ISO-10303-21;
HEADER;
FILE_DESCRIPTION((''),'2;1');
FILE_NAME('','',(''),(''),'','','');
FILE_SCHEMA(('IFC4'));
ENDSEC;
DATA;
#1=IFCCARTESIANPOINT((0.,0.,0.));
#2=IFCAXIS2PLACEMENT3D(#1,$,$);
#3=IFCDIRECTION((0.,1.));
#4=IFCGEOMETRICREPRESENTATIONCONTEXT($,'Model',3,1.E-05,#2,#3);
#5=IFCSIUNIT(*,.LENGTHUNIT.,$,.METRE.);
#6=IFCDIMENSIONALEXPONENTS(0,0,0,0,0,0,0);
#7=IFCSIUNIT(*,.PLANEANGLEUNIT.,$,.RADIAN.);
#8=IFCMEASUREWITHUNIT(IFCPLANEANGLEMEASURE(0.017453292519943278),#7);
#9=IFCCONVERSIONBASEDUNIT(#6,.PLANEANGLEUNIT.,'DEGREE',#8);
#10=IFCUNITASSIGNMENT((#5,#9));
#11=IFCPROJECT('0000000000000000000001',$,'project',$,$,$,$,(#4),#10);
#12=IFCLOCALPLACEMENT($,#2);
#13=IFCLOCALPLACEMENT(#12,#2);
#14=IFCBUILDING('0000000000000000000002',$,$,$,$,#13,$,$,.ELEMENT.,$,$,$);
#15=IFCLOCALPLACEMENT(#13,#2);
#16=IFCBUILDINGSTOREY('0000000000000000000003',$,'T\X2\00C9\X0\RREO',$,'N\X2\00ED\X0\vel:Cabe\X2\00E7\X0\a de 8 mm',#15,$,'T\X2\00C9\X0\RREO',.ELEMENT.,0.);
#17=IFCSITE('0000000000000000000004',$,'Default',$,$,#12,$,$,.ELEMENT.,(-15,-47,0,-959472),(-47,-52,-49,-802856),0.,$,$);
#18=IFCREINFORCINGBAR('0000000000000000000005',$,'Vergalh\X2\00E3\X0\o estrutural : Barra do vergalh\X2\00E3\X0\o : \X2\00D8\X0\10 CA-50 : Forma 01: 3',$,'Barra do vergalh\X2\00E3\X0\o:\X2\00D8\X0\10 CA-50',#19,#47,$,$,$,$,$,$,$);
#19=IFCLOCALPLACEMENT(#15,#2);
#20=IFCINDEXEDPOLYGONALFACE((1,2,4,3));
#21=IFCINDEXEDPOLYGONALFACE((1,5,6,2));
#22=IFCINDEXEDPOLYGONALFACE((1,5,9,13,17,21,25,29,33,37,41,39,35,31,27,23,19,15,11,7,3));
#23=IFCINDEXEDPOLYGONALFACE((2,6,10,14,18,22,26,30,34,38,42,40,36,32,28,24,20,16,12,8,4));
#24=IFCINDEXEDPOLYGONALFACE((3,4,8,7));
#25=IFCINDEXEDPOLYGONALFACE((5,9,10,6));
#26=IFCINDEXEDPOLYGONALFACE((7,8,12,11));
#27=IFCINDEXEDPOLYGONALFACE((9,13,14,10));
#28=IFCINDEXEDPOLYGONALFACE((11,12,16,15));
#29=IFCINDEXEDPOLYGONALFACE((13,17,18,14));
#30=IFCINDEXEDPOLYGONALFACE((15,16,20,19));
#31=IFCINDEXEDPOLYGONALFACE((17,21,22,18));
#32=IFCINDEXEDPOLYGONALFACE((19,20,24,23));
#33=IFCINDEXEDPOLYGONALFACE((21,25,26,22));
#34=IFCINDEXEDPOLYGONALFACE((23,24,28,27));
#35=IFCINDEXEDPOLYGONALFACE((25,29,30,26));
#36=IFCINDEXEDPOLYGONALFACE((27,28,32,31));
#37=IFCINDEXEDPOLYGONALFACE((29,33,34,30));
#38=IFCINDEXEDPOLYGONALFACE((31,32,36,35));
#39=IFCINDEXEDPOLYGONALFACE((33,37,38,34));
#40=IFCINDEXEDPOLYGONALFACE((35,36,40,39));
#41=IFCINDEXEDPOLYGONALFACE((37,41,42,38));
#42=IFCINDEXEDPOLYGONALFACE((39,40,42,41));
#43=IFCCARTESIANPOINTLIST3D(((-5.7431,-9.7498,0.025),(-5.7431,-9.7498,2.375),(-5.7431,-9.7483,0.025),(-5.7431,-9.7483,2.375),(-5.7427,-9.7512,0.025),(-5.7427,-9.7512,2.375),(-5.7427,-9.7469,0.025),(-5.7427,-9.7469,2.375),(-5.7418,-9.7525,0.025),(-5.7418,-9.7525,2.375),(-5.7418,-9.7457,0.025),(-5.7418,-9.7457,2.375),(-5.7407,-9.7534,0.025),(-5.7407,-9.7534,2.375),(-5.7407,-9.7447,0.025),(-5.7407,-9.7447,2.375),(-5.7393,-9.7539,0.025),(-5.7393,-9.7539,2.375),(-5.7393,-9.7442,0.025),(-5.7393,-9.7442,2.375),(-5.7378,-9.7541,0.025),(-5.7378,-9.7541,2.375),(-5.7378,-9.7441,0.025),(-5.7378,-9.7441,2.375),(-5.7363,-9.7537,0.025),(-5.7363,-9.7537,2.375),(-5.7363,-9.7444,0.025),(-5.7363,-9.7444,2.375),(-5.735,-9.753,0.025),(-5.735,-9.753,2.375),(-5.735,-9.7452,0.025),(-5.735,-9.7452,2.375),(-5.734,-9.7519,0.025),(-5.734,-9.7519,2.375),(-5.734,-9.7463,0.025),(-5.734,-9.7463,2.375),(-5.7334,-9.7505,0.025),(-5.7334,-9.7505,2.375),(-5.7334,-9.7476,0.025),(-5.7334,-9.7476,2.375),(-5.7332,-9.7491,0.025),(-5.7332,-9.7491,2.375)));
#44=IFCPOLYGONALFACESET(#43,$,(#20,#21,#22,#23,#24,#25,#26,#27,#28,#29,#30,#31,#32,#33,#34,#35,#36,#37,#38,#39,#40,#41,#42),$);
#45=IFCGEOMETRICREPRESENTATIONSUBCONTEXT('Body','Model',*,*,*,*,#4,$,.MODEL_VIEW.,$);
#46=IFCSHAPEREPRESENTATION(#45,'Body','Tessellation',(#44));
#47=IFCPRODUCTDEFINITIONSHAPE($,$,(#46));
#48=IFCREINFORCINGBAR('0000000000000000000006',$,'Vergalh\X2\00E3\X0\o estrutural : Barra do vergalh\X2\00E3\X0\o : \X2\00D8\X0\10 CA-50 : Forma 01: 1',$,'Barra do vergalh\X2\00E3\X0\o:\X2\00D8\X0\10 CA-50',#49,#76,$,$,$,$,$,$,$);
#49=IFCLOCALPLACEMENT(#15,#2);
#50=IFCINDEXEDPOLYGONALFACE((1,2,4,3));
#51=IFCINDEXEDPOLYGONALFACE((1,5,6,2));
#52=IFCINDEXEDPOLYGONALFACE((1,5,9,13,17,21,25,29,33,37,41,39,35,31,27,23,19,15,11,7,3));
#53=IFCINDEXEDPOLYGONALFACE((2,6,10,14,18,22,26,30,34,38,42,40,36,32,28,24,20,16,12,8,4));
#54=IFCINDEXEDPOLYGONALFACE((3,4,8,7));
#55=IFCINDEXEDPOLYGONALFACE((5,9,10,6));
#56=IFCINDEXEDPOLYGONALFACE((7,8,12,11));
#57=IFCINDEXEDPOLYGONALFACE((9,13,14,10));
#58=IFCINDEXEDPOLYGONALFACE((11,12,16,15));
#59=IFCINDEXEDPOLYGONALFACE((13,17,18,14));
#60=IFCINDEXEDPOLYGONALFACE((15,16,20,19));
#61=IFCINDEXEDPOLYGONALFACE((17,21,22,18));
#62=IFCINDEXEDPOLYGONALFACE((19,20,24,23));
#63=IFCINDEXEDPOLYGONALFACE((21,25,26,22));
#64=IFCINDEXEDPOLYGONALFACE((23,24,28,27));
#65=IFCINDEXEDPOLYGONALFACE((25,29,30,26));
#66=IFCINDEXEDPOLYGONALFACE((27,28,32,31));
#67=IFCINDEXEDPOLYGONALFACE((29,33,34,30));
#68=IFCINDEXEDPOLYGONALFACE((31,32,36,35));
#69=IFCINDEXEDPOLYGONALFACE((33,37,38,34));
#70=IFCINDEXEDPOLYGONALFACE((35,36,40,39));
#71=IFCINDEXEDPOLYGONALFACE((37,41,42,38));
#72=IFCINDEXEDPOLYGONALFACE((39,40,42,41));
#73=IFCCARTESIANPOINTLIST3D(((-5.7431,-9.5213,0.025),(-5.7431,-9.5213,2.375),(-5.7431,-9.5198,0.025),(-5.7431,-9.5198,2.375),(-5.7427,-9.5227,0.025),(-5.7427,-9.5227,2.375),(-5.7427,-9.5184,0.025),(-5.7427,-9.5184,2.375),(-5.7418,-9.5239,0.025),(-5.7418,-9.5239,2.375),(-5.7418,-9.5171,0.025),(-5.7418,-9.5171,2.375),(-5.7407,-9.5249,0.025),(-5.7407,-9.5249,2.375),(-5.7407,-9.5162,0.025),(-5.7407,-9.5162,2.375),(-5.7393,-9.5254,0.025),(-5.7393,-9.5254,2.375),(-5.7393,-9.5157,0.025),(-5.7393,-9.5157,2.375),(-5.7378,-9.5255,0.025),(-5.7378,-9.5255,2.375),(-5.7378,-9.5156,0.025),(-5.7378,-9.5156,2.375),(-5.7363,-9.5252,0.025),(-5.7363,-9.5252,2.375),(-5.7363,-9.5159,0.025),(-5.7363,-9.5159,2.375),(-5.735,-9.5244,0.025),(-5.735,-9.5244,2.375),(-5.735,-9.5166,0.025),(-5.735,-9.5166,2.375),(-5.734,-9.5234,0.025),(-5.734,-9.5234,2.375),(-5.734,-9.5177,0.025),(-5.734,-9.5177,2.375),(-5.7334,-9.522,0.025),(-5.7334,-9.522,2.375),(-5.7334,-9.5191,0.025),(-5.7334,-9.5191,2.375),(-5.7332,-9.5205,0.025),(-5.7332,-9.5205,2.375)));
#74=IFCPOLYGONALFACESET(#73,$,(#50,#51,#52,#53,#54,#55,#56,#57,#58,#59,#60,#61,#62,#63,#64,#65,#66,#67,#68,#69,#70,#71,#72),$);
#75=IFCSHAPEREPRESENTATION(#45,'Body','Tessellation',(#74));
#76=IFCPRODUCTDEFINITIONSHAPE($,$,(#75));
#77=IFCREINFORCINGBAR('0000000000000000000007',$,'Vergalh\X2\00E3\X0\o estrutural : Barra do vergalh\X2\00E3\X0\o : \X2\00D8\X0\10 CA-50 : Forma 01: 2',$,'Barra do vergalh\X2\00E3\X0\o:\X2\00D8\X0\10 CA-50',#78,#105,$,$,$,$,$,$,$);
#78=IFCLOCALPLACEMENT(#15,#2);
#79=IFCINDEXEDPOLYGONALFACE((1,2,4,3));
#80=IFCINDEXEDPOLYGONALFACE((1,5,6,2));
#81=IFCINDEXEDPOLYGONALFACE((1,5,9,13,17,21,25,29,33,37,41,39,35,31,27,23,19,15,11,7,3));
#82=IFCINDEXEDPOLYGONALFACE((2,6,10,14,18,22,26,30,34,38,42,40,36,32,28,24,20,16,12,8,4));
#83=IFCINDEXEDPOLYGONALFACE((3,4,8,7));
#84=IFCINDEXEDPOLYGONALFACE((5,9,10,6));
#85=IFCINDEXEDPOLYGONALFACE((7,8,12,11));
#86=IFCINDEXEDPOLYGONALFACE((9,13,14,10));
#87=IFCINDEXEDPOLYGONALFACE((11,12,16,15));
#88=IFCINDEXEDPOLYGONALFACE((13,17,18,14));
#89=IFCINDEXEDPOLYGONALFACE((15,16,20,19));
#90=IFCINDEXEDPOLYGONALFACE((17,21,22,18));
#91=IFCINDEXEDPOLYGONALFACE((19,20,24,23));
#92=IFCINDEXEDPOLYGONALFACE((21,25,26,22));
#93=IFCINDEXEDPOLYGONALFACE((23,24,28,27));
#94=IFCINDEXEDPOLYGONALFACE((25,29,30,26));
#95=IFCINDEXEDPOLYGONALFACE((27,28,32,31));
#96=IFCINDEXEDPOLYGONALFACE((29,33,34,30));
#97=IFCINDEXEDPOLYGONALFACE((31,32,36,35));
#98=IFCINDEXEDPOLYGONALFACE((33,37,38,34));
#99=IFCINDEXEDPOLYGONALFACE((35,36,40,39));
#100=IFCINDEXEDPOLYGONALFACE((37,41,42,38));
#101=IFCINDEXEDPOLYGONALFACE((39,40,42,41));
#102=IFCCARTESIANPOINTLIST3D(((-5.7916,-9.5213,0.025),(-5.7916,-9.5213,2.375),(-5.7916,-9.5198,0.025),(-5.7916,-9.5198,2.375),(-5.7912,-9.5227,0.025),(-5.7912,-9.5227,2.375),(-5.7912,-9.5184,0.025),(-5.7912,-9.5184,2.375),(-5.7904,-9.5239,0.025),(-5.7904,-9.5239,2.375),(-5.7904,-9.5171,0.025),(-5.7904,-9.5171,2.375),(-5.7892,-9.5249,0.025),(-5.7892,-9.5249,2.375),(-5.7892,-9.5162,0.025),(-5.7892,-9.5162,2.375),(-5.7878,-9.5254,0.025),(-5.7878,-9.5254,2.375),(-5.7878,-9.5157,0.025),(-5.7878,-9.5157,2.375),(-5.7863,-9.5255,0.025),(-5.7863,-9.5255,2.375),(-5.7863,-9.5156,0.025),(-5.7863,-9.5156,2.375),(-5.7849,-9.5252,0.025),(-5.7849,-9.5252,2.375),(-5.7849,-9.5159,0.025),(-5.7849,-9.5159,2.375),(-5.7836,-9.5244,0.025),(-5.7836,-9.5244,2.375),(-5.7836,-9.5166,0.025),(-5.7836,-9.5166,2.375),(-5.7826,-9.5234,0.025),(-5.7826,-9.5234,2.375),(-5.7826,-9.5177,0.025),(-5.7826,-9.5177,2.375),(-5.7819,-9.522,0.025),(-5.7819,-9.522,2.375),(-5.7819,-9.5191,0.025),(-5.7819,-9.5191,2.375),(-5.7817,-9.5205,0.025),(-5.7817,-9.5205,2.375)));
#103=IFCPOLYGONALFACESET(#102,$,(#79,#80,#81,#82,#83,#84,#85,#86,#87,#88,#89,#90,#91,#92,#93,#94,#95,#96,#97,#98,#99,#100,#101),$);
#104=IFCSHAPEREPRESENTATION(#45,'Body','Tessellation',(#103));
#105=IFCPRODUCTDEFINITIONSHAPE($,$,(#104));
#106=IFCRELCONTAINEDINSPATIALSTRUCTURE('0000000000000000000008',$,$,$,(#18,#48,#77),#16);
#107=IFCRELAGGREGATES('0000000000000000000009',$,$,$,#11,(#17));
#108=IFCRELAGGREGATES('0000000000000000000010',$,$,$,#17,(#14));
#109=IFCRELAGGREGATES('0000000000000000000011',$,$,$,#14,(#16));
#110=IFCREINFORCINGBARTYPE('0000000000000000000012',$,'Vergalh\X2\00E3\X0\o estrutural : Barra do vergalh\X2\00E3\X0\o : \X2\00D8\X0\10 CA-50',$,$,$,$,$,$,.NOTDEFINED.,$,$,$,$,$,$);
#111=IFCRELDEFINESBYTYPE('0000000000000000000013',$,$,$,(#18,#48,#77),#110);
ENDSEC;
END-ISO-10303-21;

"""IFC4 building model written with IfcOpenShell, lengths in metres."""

from ifc_helpers import new_model, entity, si_unit, converted_unit, direction, origin, place, context, subcontext, project, spatial, type_object, element, save


model = new_model("IFC4")

# Units and contexts
model_context = context("Model", 3, precision=1e-05, world=origin(), true_north=direction((0.0, 1.0)))
body_context = subcontext(model_context, "Body", "Model", "MODEL_VIEW")
ifc_project = project(units=[si_unit("LENGTHUNIT", "METRE"), converted_unit("PLANEANGLEUNIT", "DEGREE", entity("IfcPlaneAngleMeasure", 0.017453292519943278), si_unit("PLANEANGLEUNIT", "RADIAN"), dimensions=[0, 0, 0, 0, 0, 0, 0])], contexts=[model_context])

# Site, building, storey
site_placement = place(None, origin())
site = spatial("IfcSite", under=ifc_project, at=site_placement, Name="Default", CompositionType="ELEMENT", RefLatitude=(-15, -47, 0, -959472), RefLongitude=(-47, -52, -49, -802856), RefElevation=0.0)
building_placement = place(site_placement, origin())
building = spatial("IfcBuilding", under=site, at=building_placement, CompositionType="ELEMENT")
storey_placement = place(building_placement, origin())
storey = spatial("IfcBuildingStorey", under=building, at=storey_placement, Name="TÉRREO", ObjectType="Nível:Cabeça de 8 mm", LongName="TÉRREO", CompositionType="ELEMENT", Elevation=0.0)

# Reinforcing bars
reinforcing_bar_type_1 = type_object("IfcReinforcingBarType", Name="Vergalhão estrutural : Barra do vergalhão : Ø10 CA-50", PredefinedType="NOTDEFINED")
reinforcing_bar_1_placement = place(storey_placement, origin())
element("IfcReinforcingBar", 1, at=reinforcing_bar_1_placement, inside=storey, type_object=reinforcing_bar_type_1, Name="Vergalhão estrutural : Barra do vergalhão : Ø10 CA-50 : Forma 01: 3", ObjectType="Barra do vergalhão:Ø10 CA-50", context=body_context, shape_type="AdvancedSweptSolid", body=[
    entity("IfcSweptDiskSolid", entity("IfcIndexedPolyCurve", entity("IfcCartesianPointList3D", [[-5.7382, -9.7491, 0.025], [-5.7382, -9.7491, 2.375]]), None, False), 0.005, None, 0.0, 1.0),
])
reinforcing_bar_2_placement = place(storey_placement, origin())
element("IfcReinforcingBar", 2, at=reinforcing_bar_2_placement, inside=storey, type_object=reinforcing_bar_type_1, Name="Vergalhão estrutural : Barra do vergalhão : Ø10 CA-50 : Forma 01: 1", ObjectType="Barra do vergalhão:Ø10 CA-50", context=body_context, shape_type="AdvancedSweptSolid", body=[
    entity("IfcSweptDiskSolid", entity("IfcIndexedPolyCurve", entity("IfcCartesianPointList3D", [[-5.7382, -9.5205, 0.025], [-5.7382, -9.5205, 2.375]]), None, False), 0.005, None, 0.0, 1.0),
])
reinforcing_bar_3_placement = place(storey_placement, origin())
element("IfcReinforcingBar", 3, at=reinforcing_bar_3_placement, inside=storey, type_object=reinforcing_bar_type_1, Name="Vergalhão estrutural : Barra do vergalhão : Ø10 CA-50 : Forma 01: 2", ObjectType="Barra do vergalhão:Ø10 CA-50", context=body_context, shape_type="AdvancedSweptSolid", body=[
    entity("IfcSweptDiskSolid", entity("IfcIndexedPolyCurve", entity("IfcCartesianPointList3D", [[-5.7867, -9.5205, 0.025], [-5.7867, -9.5205, 2.375]]), None, False), 0.005, None, 0.0, 1.0),
])

save(model, "model.ifc")
